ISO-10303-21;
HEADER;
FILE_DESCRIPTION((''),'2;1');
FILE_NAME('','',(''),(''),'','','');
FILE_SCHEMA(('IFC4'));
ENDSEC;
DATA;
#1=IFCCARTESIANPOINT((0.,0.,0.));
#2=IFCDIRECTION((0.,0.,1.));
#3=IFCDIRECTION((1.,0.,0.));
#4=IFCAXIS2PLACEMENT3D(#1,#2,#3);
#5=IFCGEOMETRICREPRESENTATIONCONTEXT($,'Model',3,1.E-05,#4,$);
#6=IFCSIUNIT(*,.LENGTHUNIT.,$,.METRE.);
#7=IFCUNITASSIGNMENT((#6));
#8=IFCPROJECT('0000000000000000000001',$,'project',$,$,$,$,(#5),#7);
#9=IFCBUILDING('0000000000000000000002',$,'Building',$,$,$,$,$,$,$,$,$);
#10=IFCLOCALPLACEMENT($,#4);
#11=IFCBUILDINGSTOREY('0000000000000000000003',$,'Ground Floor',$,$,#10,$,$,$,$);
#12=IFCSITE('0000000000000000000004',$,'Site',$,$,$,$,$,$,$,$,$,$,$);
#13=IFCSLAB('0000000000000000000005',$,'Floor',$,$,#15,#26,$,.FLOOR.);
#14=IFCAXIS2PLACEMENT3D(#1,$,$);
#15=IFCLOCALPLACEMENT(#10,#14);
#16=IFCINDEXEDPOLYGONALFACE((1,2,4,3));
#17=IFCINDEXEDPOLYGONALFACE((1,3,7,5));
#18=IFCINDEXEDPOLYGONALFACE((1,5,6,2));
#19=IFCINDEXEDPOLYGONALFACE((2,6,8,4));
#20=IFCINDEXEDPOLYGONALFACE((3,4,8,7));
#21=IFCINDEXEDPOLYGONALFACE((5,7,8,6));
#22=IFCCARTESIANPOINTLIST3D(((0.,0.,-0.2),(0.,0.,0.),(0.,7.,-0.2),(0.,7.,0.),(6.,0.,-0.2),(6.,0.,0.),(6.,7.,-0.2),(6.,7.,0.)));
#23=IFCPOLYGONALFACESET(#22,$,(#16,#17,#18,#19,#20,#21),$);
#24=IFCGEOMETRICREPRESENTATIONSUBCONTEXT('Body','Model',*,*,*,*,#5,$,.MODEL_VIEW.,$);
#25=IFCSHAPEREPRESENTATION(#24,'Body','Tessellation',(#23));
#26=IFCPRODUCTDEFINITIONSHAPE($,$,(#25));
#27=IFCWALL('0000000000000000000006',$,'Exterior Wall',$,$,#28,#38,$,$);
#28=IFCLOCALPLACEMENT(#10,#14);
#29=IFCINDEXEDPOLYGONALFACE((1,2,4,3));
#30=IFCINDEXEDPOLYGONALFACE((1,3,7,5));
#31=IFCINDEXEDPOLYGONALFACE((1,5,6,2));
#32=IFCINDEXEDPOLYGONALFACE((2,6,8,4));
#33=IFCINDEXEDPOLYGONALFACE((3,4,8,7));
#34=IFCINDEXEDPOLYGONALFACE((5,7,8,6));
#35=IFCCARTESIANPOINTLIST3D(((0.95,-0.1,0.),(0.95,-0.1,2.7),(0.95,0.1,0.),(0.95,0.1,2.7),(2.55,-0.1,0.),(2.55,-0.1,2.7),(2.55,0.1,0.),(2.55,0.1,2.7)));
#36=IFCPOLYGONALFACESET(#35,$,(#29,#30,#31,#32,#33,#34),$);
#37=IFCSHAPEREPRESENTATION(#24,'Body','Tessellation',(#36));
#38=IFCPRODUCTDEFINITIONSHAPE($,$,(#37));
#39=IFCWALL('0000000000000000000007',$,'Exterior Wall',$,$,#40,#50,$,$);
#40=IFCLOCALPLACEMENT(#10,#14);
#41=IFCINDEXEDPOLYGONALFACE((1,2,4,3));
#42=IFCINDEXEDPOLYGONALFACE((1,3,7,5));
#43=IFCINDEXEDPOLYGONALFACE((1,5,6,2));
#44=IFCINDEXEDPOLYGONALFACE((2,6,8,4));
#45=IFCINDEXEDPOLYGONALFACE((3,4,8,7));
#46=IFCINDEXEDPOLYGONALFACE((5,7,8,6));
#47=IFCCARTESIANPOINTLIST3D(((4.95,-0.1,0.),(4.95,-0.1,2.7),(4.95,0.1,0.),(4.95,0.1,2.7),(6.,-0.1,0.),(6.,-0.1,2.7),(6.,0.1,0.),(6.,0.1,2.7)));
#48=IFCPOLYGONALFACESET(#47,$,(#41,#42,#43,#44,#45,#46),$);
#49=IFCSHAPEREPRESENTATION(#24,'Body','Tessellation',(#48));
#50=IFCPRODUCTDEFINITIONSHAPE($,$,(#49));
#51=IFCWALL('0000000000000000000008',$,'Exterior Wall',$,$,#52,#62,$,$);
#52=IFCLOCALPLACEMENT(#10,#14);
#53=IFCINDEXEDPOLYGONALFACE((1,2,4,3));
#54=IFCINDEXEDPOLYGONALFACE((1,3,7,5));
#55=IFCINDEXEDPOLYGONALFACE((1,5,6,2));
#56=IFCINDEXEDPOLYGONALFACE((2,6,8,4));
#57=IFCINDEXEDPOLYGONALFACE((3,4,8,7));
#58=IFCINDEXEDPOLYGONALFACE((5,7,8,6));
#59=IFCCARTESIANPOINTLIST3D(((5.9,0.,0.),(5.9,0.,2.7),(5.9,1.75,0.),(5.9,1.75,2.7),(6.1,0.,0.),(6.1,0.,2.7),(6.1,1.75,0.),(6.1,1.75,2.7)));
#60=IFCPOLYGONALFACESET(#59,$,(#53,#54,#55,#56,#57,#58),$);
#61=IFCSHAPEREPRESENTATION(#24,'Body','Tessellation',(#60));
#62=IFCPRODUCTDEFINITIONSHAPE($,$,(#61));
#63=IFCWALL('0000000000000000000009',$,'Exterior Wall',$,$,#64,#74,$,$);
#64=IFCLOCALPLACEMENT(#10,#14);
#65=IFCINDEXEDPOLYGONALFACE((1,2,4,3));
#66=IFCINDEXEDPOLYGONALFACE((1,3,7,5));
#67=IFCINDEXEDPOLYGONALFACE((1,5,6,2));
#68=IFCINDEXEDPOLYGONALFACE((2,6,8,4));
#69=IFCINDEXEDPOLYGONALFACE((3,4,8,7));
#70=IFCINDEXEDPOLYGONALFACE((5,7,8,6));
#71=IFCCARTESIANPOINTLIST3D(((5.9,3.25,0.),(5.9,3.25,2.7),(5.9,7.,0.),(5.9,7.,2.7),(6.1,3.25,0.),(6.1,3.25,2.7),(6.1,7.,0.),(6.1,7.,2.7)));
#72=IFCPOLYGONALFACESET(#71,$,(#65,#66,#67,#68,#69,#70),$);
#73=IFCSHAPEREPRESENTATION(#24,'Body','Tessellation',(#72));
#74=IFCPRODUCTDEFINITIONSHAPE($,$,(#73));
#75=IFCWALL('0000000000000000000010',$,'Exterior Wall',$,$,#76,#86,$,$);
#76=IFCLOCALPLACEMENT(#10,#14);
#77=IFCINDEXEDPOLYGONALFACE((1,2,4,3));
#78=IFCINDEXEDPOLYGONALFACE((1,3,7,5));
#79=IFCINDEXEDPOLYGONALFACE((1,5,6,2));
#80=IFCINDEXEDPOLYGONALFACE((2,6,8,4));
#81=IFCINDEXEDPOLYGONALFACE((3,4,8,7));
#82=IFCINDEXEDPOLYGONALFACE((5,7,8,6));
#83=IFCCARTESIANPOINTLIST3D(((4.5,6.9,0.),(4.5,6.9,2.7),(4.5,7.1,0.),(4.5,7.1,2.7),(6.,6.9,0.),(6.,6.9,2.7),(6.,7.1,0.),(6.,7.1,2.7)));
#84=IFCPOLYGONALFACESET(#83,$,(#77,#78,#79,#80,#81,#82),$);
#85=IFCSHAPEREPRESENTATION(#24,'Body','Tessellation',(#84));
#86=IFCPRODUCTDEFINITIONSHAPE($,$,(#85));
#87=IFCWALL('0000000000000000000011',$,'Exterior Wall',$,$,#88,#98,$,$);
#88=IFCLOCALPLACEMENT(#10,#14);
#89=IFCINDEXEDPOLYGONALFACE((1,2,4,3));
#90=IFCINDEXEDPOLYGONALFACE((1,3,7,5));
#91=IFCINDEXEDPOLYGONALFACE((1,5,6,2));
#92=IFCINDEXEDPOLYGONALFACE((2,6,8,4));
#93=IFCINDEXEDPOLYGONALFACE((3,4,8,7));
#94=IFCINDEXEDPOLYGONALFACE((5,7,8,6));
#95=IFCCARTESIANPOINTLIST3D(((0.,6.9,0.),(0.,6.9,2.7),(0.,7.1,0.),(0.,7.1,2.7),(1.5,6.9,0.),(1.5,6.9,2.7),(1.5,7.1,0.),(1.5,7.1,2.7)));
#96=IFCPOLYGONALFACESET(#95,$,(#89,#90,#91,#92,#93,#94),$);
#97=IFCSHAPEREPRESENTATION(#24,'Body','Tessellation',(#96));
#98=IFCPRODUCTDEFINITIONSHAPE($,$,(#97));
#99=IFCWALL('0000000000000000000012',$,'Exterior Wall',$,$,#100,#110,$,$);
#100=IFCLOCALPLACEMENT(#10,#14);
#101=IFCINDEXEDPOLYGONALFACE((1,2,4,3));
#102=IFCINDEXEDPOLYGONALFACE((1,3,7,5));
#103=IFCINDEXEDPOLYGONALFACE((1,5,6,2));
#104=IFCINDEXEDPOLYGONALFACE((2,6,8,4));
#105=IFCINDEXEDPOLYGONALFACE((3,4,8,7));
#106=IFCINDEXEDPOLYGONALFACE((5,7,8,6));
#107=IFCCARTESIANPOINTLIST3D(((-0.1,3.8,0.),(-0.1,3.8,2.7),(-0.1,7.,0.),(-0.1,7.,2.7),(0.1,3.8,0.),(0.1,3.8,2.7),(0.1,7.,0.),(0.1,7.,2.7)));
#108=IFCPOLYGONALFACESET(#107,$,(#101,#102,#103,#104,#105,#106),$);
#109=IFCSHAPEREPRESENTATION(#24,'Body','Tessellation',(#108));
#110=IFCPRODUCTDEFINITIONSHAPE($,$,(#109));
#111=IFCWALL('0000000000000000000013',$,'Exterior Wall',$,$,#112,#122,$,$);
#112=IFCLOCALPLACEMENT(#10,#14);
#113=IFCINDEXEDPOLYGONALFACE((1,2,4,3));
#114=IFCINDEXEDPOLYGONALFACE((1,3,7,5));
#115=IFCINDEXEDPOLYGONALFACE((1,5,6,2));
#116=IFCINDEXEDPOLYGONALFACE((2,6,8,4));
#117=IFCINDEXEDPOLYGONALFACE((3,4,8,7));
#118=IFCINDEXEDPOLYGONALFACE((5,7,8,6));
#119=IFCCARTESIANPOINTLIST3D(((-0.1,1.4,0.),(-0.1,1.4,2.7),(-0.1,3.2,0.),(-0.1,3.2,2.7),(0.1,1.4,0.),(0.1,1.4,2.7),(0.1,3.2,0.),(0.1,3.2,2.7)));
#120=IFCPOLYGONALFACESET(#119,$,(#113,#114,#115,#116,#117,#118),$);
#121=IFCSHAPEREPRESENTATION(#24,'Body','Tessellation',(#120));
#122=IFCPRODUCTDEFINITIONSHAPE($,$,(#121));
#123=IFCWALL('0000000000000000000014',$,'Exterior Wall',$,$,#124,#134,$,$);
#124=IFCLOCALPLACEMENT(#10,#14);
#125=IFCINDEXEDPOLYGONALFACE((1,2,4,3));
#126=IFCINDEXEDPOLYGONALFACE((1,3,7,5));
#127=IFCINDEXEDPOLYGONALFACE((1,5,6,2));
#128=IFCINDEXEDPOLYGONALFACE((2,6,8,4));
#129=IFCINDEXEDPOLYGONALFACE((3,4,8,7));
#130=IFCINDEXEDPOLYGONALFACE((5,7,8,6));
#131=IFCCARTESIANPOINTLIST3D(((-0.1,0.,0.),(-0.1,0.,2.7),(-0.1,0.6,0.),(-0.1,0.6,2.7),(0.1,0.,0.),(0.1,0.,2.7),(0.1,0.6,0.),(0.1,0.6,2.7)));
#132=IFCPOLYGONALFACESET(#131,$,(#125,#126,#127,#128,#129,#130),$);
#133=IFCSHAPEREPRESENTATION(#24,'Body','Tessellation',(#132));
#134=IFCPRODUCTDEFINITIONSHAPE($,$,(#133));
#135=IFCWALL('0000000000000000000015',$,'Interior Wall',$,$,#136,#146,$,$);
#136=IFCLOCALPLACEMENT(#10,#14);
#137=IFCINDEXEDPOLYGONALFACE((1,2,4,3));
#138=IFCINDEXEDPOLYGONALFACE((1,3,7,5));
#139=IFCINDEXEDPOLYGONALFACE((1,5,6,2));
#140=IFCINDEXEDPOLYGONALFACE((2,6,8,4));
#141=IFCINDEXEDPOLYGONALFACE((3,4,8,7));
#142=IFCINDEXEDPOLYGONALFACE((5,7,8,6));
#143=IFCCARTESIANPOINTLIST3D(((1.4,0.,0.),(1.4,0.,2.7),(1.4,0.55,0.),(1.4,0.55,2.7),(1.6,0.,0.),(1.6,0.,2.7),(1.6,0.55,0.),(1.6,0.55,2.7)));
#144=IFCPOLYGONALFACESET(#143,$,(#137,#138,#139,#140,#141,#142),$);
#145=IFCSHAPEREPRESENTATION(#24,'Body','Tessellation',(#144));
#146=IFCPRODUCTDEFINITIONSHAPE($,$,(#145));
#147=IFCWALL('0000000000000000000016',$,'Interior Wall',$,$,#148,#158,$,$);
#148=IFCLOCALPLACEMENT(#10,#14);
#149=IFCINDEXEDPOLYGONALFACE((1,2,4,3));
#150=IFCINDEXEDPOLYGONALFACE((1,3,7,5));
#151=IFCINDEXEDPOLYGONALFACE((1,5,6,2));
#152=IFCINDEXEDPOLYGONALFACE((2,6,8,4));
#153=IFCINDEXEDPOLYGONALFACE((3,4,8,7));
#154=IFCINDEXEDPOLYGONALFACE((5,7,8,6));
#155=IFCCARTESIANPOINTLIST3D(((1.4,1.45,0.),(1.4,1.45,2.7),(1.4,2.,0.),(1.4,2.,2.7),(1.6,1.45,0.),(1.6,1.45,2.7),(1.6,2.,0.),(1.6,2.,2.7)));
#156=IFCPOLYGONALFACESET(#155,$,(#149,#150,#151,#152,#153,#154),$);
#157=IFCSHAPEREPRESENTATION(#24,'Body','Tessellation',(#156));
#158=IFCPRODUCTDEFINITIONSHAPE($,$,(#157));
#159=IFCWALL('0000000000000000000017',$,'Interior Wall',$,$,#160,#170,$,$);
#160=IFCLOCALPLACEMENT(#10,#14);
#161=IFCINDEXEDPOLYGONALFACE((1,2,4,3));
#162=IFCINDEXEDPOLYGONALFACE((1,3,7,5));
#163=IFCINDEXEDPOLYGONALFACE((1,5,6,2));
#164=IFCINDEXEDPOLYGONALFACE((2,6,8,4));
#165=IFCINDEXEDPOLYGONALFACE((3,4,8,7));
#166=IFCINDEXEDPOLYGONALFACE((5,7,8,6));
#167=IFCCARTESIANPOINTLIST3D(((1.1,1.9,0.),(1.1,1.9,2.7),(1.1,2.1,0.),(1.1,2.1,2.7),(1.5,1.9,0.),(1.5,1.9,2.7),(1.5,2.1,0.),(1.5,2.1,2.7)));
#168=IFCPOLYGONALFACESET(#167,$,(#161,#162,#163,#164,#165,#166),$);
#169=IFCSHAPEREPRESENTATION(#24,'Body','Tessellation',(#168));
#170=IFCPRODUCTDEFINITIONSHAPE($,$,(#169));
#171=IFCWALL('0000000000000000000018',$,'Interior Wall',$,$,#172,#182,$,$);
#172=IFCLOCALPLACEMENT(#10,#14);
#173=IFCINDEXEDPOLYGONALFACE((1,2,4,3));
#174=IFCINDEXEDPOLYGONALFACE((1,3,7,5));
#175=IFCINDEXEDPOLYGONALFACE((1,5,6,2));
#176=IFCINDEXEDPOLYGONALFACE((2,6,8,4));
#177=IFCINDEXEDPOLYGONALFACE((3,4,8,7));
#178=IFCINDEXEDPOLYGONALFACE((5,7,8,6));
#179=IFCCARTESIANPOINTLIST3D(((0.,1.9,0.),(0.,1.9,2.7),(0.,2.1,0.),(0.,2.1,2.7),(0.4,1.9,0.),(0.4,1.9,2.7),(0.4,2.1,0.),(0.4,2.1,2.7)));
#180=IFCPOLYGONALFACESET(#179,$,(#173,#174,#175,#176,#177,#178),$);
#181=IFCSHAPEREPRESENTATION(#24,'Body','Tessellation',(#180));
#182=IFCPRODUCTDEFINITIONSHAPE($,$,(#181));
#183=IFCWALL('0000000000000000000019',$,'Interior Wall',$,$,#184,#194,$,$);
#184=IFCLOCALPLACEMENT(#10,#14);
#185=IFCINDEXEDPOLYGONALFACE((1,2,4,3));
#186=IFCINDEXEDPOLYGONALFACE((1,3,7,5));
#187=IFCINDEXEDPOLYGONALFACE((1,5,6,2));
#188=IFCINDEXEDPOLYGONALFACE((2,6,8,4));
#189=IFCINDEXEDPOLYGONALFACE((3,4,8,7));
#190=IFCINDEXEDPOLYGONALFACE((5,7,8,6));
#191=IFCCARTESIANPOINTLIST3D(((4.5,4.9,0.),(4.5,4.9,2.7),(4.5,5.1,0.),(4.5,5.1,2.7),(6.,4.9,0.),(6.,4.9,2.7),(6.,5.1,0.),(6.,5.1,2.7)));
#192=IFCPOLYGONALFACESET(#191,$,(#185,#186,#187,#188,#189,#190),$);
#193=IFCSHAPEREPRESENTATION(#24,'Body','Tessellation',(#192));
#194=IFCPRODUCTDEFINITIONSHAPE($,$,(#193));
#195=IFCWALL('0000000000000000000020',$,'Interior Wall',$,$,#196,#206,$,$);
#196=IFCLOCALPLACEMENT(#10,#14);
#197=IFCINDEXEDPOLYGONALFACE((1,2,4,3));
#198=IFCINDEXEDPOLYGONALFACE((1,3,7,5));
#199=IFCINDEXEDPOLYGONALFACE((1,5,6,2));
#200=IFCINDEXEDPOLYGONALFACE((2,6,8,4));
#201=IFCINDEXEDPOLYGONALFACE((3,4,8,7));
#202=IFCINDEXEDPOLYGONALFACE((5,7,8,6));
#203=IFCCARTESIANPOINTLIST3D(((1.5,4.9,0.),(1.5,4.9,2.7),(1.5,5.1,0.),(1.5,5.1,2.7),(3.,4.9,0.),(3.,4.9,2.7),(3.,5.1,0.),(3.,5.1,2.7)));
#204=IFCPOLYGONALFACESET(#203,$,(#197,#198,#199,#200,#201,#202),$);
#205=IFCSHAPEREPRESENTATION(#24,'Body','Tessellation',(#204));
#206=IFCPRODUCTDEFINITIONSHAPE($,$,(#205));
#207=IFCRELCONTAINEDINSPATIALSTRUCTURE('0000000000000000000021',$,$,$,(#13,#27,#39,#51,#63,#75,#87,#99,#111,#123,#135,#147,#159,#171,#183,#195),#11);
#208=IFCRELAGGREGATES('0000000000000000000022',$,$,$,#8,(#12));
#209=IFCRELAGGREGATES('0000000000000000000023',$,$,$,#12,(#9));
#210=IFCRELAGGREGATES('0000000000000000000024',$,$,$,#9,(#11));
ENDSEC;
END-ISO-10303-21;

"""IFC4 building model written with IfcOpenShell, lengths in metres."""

from ifc_helpers import new_model, si_unit, frame, origin_with_axes, place, context, subcontext, project, spatial, indexed_curve, outline, extrude, element, save


model = new_model("IFC4")

# Units and contexts
model_context = context("Model", 3, precision=1e-05, world=origin_with_axes())
body_context = subcontext(model_context, "Body", "Model", "MODEL_VIEW")
ifc_project = project(units=[si_unit("LENGTHUNIT", "METRE")], contexts=[model_context])

# Site, building, storey
site = spatial("IfcSite", under=ifc_project, Name="Site")
building = spatial("IfcBuilding", under=site, Name="Building")
storey_placement = place(None, origin_with_axes())
storey = spatial("IfcBuildingStorey", under=building, at=storey_placement, Name="Ground Floor")

# Slab
slab_placement = place(storey_placement, frame((0.0, 0.0, -0.2), z_axis=(0.0, 0.0, 1.0), x_axis=(1.0, 0.0, 0.0)))
element("IfcSlab", 1, at=slab_placement, inside=storey, Name="Floor", PredefinedType="FLOOR", context=body_context, shape_type="SweptSolid", body=[
    extrude(outline(indexed_curve([(0.0, 0.0), (6.0, 0.0), (6.0, 7.0), (0.0, 7.0)])), None, (0.0, 0.0, 1.0), 0.2),
])

# Walls
wall_1_placement = place(storey_placement, frame((0.95, 0.0, 0.0), z_axis=(0.0, 0.0, 1.0), x_axis=(1.0, 0.0, 0.0)))
element("IfcWall", 2, at=wall_1_placement, inside=storey, Name="Exterior Wall", context=body_context, shape_type="SweptSolid", body=[
    extrude(outline(indexed_curve([(0.0, 0.0), (0.0, 0.2), (1.6, 0.2), (1.6, 0.0), (0.0, 0.0)], self_intersect=False)), frame((0.0, -0.1, 0.0), z_axis=(0.0, 0.0, 1.0), x_axis=(1.0, 0.0, 0.0)), (0.0, 0.0, 1.0), 2.7),
])
wall_2_placement = place(storey_placement, frame((4.95, 0.0, 0.0), z_axis=(0.0, 0.0, 1.0), x_axis=(1.0, 0.0, 0.0)))
element("IfcWall", 3, at=wall_2_placement, inside=storey, Name="Exterior Wall", context=body_context, shape_type="SweptSolid", body=[
    extrude(outline(indexed_curve([(0.0, 0.0), (0.0, 0.2), (1.05, 0.2), (1.05, 0.0), (0.0, 0.0)], self_intersect=False)), frame((0.0, -0.1, 0.0), z_axis=(0.0, 0.0, 1.0), x_axis=(1.0, 0.0, 0.0)), (0.0, 0.0, 1.0), 2.7),
])
wall_3_placement = place(storey_placement, frame((6.0, 0.0, 0.0), z_axis=(0.0, 0.0, 1.0), x_axis=(0.0, 1.0, 0.0)))
element("IfcWall", 4, at=wall_3_placement, inside=storey, Name="Exterior Wall", context=body_context, shape_type="SweptSolid", body=[
    extrude(outline(indexed_curve([(0.0, 0.0), (0.0, 0.2), (1.75, 0.2), (1.75, 0.0), (0.0, 0.0)], self_intersect=False)), frame((0.0, -0.1, 0.0), z_axis=(0.0, 0.0, 1.0), x_axis=(1.0, 0.0, 0.0)), (0.0, 0.0, 1.0), 2.7),
])
wall_4_placement = place(storey_placement, frame((6.0, 3.25, 0.0), z_axis=(0.0, 0.0, 1.0), x_axis=(0.0, 1.0, 0.0)))
element("IfcWall", 5, at=wall_4_placement, inside=storey, Name="Exterior Wall", context=body_context, shape_type="SweptSolid", body=[
    extrude(outline(indexed_curve([(0.0, 0.0), (0.0, 0.2), (3.75, 0.2), (3.75, 0.0), (0.0, 0.0)], self_intersect=False)), frame((0.0, -0.1, 0.0), z_axis=(0.0, 0.0, 1.0), x_axis=(1.0, 0.0, 0.0)), (0.0, 0.0, 1.0), 2.7),
])
for number, where, z_axis, x_axis, name in (
    (6, (6.0, 7.0, 0.0), (0.0, 0.0, 1.0), (-1.0, 0.0, 0.0), "Exterior Wall"),
    (7, (1.5, 7.0, 0.0), (0.0, 0.0, 1.0), (-1.0, 0.0, 0.0), "Exterior Wall"),
):
    element("IfcWall", number, at=place(storey_placement, frame(where, z_axis=z_axis, x_axis=x_axis)), inside=storey, Name=name, context=body_context, shape_type="SweptSolid", body=[
        extrude(outline(indexed_curve([(0.0, 0.0), (0.0, 0.2), (1.5, 0.2), (1.5, 0.0), (0.0, 0.0)], self_intersect=False)), frame((0.0, -0.1, 0.0), z_axis=(0.0, 0.0, 1.0), x_axis=(1.0, 0.0, 0.0)), (0.0, 0.0, 1.0), 2.7),
    ])
wall_5_placement = place(storey_placement, frame((0.0, 7.0, 0.0), z_axis=(0.0, 0.0, 1.0), x_axis=(0.0, -1.0, 0.0)))
element("IfcWall", 8, at=wall_5_placement, inside=storey, Name="Exterior Wall", context=body_context, shape_type="SweptSolid", body=[
    extrude(outline(indexed_curve([(0.0, 0.0), (0.0, 0.2), (3.2, 0.2), (3.2, 0.0), (0.0, 0.0)], self_intersect=False)), frame((0.0, -0.1, 0.0), z_axis=(0.0, 0.0, 1.0), x_axis=(1.0, 0.0, 0.0)), (0.0, 0.0, 1.0), 2.7),
])
wall_6_placement = place(storey_placement, frame((0.0, 3.2, 0.0), z_axis=(0.0, 0.0, 1.0), x_axis=(0.0, -1.0, 0.0)))
element("IfcWall", 9, at=wall_6_placement, inside=storey, Name="Exterior Wall", context=body_context, shape_type="SweptSolid", body=[
    extrude(outline(indexed_curve([(0.0, 0.0), (0.0, 0.2), (1.8, 0.2), (1.8, 0.0), (0.0, 0.0)], self_intersect=False)), frame((0.0, -0.1, 0.0), z_axis=(0.0, 0.0, 1.0), x_axis=(1.0, 0.0, 0.0)), (0.0, 0.0, 1.0), 2.7),
])
wall_7_placement = place(storey_placement, frame((0.0, 0.6, 0.0), z_axis=(0.0, 0.0, 1.0), x_axis=(0.0, -1.0, 0.0)))
element("IfcWall", 10, at=wall_7_placement, inside=storey, Name="Exterior Wall", context=body_context, shape_type="SweptSolid", body=[
    extrude(outline(indexed_curve([(0.0, 0.0), (0.0, 0.2), (0.6, 0.2), (0.6, 0.0), (0.0, 0.0)], self_intersect=False)), frame((0.0, -0.1, 0.0), z_axis=(0.0, 0.0, 1.0), x_axis=(1.0, 0.0, 0.0)), (0.0, 0.0, 1.0), 2.7),
])
for number, where, z_axis, x_axis, name in (
    (11, (1.5, 0.0, 0.0), (0.0, 0.0, 1.0), (0.0, 1.0, 0.0), "Interior Wall"),
    (12, (1.5, 1.45, 0.0), (0.0, 0.0, 1.0), (0.0, 1.0, 0.0), "Interior Wall"),
):
    element("IfcWall", number, at=place(storey_placement, frame(where, z_axis=z_axis, x_axis=x_axis)), inside=storey, Name=name, context=body_context, shape_type="SweptSolid", body=[
        extrude(outline(indexed_curve([(0.0, 0.0), (0.0, 0.2), (0.55, 0.2), (0.55, 0.0), (0.0, 0.0)], self_intersect=False)), frame((0.0, -0.1, 0.0), z_axis=(0.0, 0.0, 1.0), x_axis=(1.0, 0.0, 0.0)), (0.0, 0.0, 1.0), 2.7),
    ])
for number, where, z_axis, x_axis, name in (
    (13, (1.5, 2.0, 0.0), (0.0, 0.0, 1.0), (-1.0, 0.0, 0.0), "Interior Wall"),
    (14, (0.4, 2.0, 0.0), (0.0, 0.0, 1.0), (-1.0, 0.0, 0.0), "Interior Wall"),
):
    element("IfcWall", number, at=place(storey_placement, frame(where, z_axis=z_axis, x_axis=x_axis)), inside=storey, Name=name, context=body_context, shape_type="SweptSolid", body=[
        extrude(outline(indexed_curve([(0.0, 0.0), (0.0, 0.2), (0.4, 0.2), (0.4, 0.0), (0.0, 0.0)], self_intersect=False)), frame((0.0, -0.1, 0.0), z_axis=(0.0, 0.0, 1.0), x_axis=(1.0, 0.0, 0.0)), (0.0, 0.0, 1.0), 2.7),
    ])
for number, where, z_axis, x_axis, name in (
    (15, (6.0, 5.0, 0.0), (0.0, 0.0, 1.0), (-1.0, 0.0, 0.0), "Interior Wall"),
    (16, (3.0, 5.0, 0.0), (0.0, 0.0, 1.0), (-1.0, 0.0, 0.0), "Interior Wall"),
):
    element("IfcWall", number, at=place(storey_placement, frame(where, z_axis=z_axis, x_axis=x_axis)), inside=storey, Name=name, context=body_context, shape_type="SweptSolid", body=[
        extrude(outline(indexed_curve([(0.0, 0.0), (0.0, 0.2), (1.5, 0.2), (1.5, 0.0), (0.0, 0.0)], self_intersect=False)), frame((0.0, -0.1, 0.0), z_axis=(0.0, 0.0, 1.0), x_axis=(1.0, 0.0, 0.0)), (0.0, 0.0, 1.0), 2.7),
    ])

save(model, "model.ifc")
